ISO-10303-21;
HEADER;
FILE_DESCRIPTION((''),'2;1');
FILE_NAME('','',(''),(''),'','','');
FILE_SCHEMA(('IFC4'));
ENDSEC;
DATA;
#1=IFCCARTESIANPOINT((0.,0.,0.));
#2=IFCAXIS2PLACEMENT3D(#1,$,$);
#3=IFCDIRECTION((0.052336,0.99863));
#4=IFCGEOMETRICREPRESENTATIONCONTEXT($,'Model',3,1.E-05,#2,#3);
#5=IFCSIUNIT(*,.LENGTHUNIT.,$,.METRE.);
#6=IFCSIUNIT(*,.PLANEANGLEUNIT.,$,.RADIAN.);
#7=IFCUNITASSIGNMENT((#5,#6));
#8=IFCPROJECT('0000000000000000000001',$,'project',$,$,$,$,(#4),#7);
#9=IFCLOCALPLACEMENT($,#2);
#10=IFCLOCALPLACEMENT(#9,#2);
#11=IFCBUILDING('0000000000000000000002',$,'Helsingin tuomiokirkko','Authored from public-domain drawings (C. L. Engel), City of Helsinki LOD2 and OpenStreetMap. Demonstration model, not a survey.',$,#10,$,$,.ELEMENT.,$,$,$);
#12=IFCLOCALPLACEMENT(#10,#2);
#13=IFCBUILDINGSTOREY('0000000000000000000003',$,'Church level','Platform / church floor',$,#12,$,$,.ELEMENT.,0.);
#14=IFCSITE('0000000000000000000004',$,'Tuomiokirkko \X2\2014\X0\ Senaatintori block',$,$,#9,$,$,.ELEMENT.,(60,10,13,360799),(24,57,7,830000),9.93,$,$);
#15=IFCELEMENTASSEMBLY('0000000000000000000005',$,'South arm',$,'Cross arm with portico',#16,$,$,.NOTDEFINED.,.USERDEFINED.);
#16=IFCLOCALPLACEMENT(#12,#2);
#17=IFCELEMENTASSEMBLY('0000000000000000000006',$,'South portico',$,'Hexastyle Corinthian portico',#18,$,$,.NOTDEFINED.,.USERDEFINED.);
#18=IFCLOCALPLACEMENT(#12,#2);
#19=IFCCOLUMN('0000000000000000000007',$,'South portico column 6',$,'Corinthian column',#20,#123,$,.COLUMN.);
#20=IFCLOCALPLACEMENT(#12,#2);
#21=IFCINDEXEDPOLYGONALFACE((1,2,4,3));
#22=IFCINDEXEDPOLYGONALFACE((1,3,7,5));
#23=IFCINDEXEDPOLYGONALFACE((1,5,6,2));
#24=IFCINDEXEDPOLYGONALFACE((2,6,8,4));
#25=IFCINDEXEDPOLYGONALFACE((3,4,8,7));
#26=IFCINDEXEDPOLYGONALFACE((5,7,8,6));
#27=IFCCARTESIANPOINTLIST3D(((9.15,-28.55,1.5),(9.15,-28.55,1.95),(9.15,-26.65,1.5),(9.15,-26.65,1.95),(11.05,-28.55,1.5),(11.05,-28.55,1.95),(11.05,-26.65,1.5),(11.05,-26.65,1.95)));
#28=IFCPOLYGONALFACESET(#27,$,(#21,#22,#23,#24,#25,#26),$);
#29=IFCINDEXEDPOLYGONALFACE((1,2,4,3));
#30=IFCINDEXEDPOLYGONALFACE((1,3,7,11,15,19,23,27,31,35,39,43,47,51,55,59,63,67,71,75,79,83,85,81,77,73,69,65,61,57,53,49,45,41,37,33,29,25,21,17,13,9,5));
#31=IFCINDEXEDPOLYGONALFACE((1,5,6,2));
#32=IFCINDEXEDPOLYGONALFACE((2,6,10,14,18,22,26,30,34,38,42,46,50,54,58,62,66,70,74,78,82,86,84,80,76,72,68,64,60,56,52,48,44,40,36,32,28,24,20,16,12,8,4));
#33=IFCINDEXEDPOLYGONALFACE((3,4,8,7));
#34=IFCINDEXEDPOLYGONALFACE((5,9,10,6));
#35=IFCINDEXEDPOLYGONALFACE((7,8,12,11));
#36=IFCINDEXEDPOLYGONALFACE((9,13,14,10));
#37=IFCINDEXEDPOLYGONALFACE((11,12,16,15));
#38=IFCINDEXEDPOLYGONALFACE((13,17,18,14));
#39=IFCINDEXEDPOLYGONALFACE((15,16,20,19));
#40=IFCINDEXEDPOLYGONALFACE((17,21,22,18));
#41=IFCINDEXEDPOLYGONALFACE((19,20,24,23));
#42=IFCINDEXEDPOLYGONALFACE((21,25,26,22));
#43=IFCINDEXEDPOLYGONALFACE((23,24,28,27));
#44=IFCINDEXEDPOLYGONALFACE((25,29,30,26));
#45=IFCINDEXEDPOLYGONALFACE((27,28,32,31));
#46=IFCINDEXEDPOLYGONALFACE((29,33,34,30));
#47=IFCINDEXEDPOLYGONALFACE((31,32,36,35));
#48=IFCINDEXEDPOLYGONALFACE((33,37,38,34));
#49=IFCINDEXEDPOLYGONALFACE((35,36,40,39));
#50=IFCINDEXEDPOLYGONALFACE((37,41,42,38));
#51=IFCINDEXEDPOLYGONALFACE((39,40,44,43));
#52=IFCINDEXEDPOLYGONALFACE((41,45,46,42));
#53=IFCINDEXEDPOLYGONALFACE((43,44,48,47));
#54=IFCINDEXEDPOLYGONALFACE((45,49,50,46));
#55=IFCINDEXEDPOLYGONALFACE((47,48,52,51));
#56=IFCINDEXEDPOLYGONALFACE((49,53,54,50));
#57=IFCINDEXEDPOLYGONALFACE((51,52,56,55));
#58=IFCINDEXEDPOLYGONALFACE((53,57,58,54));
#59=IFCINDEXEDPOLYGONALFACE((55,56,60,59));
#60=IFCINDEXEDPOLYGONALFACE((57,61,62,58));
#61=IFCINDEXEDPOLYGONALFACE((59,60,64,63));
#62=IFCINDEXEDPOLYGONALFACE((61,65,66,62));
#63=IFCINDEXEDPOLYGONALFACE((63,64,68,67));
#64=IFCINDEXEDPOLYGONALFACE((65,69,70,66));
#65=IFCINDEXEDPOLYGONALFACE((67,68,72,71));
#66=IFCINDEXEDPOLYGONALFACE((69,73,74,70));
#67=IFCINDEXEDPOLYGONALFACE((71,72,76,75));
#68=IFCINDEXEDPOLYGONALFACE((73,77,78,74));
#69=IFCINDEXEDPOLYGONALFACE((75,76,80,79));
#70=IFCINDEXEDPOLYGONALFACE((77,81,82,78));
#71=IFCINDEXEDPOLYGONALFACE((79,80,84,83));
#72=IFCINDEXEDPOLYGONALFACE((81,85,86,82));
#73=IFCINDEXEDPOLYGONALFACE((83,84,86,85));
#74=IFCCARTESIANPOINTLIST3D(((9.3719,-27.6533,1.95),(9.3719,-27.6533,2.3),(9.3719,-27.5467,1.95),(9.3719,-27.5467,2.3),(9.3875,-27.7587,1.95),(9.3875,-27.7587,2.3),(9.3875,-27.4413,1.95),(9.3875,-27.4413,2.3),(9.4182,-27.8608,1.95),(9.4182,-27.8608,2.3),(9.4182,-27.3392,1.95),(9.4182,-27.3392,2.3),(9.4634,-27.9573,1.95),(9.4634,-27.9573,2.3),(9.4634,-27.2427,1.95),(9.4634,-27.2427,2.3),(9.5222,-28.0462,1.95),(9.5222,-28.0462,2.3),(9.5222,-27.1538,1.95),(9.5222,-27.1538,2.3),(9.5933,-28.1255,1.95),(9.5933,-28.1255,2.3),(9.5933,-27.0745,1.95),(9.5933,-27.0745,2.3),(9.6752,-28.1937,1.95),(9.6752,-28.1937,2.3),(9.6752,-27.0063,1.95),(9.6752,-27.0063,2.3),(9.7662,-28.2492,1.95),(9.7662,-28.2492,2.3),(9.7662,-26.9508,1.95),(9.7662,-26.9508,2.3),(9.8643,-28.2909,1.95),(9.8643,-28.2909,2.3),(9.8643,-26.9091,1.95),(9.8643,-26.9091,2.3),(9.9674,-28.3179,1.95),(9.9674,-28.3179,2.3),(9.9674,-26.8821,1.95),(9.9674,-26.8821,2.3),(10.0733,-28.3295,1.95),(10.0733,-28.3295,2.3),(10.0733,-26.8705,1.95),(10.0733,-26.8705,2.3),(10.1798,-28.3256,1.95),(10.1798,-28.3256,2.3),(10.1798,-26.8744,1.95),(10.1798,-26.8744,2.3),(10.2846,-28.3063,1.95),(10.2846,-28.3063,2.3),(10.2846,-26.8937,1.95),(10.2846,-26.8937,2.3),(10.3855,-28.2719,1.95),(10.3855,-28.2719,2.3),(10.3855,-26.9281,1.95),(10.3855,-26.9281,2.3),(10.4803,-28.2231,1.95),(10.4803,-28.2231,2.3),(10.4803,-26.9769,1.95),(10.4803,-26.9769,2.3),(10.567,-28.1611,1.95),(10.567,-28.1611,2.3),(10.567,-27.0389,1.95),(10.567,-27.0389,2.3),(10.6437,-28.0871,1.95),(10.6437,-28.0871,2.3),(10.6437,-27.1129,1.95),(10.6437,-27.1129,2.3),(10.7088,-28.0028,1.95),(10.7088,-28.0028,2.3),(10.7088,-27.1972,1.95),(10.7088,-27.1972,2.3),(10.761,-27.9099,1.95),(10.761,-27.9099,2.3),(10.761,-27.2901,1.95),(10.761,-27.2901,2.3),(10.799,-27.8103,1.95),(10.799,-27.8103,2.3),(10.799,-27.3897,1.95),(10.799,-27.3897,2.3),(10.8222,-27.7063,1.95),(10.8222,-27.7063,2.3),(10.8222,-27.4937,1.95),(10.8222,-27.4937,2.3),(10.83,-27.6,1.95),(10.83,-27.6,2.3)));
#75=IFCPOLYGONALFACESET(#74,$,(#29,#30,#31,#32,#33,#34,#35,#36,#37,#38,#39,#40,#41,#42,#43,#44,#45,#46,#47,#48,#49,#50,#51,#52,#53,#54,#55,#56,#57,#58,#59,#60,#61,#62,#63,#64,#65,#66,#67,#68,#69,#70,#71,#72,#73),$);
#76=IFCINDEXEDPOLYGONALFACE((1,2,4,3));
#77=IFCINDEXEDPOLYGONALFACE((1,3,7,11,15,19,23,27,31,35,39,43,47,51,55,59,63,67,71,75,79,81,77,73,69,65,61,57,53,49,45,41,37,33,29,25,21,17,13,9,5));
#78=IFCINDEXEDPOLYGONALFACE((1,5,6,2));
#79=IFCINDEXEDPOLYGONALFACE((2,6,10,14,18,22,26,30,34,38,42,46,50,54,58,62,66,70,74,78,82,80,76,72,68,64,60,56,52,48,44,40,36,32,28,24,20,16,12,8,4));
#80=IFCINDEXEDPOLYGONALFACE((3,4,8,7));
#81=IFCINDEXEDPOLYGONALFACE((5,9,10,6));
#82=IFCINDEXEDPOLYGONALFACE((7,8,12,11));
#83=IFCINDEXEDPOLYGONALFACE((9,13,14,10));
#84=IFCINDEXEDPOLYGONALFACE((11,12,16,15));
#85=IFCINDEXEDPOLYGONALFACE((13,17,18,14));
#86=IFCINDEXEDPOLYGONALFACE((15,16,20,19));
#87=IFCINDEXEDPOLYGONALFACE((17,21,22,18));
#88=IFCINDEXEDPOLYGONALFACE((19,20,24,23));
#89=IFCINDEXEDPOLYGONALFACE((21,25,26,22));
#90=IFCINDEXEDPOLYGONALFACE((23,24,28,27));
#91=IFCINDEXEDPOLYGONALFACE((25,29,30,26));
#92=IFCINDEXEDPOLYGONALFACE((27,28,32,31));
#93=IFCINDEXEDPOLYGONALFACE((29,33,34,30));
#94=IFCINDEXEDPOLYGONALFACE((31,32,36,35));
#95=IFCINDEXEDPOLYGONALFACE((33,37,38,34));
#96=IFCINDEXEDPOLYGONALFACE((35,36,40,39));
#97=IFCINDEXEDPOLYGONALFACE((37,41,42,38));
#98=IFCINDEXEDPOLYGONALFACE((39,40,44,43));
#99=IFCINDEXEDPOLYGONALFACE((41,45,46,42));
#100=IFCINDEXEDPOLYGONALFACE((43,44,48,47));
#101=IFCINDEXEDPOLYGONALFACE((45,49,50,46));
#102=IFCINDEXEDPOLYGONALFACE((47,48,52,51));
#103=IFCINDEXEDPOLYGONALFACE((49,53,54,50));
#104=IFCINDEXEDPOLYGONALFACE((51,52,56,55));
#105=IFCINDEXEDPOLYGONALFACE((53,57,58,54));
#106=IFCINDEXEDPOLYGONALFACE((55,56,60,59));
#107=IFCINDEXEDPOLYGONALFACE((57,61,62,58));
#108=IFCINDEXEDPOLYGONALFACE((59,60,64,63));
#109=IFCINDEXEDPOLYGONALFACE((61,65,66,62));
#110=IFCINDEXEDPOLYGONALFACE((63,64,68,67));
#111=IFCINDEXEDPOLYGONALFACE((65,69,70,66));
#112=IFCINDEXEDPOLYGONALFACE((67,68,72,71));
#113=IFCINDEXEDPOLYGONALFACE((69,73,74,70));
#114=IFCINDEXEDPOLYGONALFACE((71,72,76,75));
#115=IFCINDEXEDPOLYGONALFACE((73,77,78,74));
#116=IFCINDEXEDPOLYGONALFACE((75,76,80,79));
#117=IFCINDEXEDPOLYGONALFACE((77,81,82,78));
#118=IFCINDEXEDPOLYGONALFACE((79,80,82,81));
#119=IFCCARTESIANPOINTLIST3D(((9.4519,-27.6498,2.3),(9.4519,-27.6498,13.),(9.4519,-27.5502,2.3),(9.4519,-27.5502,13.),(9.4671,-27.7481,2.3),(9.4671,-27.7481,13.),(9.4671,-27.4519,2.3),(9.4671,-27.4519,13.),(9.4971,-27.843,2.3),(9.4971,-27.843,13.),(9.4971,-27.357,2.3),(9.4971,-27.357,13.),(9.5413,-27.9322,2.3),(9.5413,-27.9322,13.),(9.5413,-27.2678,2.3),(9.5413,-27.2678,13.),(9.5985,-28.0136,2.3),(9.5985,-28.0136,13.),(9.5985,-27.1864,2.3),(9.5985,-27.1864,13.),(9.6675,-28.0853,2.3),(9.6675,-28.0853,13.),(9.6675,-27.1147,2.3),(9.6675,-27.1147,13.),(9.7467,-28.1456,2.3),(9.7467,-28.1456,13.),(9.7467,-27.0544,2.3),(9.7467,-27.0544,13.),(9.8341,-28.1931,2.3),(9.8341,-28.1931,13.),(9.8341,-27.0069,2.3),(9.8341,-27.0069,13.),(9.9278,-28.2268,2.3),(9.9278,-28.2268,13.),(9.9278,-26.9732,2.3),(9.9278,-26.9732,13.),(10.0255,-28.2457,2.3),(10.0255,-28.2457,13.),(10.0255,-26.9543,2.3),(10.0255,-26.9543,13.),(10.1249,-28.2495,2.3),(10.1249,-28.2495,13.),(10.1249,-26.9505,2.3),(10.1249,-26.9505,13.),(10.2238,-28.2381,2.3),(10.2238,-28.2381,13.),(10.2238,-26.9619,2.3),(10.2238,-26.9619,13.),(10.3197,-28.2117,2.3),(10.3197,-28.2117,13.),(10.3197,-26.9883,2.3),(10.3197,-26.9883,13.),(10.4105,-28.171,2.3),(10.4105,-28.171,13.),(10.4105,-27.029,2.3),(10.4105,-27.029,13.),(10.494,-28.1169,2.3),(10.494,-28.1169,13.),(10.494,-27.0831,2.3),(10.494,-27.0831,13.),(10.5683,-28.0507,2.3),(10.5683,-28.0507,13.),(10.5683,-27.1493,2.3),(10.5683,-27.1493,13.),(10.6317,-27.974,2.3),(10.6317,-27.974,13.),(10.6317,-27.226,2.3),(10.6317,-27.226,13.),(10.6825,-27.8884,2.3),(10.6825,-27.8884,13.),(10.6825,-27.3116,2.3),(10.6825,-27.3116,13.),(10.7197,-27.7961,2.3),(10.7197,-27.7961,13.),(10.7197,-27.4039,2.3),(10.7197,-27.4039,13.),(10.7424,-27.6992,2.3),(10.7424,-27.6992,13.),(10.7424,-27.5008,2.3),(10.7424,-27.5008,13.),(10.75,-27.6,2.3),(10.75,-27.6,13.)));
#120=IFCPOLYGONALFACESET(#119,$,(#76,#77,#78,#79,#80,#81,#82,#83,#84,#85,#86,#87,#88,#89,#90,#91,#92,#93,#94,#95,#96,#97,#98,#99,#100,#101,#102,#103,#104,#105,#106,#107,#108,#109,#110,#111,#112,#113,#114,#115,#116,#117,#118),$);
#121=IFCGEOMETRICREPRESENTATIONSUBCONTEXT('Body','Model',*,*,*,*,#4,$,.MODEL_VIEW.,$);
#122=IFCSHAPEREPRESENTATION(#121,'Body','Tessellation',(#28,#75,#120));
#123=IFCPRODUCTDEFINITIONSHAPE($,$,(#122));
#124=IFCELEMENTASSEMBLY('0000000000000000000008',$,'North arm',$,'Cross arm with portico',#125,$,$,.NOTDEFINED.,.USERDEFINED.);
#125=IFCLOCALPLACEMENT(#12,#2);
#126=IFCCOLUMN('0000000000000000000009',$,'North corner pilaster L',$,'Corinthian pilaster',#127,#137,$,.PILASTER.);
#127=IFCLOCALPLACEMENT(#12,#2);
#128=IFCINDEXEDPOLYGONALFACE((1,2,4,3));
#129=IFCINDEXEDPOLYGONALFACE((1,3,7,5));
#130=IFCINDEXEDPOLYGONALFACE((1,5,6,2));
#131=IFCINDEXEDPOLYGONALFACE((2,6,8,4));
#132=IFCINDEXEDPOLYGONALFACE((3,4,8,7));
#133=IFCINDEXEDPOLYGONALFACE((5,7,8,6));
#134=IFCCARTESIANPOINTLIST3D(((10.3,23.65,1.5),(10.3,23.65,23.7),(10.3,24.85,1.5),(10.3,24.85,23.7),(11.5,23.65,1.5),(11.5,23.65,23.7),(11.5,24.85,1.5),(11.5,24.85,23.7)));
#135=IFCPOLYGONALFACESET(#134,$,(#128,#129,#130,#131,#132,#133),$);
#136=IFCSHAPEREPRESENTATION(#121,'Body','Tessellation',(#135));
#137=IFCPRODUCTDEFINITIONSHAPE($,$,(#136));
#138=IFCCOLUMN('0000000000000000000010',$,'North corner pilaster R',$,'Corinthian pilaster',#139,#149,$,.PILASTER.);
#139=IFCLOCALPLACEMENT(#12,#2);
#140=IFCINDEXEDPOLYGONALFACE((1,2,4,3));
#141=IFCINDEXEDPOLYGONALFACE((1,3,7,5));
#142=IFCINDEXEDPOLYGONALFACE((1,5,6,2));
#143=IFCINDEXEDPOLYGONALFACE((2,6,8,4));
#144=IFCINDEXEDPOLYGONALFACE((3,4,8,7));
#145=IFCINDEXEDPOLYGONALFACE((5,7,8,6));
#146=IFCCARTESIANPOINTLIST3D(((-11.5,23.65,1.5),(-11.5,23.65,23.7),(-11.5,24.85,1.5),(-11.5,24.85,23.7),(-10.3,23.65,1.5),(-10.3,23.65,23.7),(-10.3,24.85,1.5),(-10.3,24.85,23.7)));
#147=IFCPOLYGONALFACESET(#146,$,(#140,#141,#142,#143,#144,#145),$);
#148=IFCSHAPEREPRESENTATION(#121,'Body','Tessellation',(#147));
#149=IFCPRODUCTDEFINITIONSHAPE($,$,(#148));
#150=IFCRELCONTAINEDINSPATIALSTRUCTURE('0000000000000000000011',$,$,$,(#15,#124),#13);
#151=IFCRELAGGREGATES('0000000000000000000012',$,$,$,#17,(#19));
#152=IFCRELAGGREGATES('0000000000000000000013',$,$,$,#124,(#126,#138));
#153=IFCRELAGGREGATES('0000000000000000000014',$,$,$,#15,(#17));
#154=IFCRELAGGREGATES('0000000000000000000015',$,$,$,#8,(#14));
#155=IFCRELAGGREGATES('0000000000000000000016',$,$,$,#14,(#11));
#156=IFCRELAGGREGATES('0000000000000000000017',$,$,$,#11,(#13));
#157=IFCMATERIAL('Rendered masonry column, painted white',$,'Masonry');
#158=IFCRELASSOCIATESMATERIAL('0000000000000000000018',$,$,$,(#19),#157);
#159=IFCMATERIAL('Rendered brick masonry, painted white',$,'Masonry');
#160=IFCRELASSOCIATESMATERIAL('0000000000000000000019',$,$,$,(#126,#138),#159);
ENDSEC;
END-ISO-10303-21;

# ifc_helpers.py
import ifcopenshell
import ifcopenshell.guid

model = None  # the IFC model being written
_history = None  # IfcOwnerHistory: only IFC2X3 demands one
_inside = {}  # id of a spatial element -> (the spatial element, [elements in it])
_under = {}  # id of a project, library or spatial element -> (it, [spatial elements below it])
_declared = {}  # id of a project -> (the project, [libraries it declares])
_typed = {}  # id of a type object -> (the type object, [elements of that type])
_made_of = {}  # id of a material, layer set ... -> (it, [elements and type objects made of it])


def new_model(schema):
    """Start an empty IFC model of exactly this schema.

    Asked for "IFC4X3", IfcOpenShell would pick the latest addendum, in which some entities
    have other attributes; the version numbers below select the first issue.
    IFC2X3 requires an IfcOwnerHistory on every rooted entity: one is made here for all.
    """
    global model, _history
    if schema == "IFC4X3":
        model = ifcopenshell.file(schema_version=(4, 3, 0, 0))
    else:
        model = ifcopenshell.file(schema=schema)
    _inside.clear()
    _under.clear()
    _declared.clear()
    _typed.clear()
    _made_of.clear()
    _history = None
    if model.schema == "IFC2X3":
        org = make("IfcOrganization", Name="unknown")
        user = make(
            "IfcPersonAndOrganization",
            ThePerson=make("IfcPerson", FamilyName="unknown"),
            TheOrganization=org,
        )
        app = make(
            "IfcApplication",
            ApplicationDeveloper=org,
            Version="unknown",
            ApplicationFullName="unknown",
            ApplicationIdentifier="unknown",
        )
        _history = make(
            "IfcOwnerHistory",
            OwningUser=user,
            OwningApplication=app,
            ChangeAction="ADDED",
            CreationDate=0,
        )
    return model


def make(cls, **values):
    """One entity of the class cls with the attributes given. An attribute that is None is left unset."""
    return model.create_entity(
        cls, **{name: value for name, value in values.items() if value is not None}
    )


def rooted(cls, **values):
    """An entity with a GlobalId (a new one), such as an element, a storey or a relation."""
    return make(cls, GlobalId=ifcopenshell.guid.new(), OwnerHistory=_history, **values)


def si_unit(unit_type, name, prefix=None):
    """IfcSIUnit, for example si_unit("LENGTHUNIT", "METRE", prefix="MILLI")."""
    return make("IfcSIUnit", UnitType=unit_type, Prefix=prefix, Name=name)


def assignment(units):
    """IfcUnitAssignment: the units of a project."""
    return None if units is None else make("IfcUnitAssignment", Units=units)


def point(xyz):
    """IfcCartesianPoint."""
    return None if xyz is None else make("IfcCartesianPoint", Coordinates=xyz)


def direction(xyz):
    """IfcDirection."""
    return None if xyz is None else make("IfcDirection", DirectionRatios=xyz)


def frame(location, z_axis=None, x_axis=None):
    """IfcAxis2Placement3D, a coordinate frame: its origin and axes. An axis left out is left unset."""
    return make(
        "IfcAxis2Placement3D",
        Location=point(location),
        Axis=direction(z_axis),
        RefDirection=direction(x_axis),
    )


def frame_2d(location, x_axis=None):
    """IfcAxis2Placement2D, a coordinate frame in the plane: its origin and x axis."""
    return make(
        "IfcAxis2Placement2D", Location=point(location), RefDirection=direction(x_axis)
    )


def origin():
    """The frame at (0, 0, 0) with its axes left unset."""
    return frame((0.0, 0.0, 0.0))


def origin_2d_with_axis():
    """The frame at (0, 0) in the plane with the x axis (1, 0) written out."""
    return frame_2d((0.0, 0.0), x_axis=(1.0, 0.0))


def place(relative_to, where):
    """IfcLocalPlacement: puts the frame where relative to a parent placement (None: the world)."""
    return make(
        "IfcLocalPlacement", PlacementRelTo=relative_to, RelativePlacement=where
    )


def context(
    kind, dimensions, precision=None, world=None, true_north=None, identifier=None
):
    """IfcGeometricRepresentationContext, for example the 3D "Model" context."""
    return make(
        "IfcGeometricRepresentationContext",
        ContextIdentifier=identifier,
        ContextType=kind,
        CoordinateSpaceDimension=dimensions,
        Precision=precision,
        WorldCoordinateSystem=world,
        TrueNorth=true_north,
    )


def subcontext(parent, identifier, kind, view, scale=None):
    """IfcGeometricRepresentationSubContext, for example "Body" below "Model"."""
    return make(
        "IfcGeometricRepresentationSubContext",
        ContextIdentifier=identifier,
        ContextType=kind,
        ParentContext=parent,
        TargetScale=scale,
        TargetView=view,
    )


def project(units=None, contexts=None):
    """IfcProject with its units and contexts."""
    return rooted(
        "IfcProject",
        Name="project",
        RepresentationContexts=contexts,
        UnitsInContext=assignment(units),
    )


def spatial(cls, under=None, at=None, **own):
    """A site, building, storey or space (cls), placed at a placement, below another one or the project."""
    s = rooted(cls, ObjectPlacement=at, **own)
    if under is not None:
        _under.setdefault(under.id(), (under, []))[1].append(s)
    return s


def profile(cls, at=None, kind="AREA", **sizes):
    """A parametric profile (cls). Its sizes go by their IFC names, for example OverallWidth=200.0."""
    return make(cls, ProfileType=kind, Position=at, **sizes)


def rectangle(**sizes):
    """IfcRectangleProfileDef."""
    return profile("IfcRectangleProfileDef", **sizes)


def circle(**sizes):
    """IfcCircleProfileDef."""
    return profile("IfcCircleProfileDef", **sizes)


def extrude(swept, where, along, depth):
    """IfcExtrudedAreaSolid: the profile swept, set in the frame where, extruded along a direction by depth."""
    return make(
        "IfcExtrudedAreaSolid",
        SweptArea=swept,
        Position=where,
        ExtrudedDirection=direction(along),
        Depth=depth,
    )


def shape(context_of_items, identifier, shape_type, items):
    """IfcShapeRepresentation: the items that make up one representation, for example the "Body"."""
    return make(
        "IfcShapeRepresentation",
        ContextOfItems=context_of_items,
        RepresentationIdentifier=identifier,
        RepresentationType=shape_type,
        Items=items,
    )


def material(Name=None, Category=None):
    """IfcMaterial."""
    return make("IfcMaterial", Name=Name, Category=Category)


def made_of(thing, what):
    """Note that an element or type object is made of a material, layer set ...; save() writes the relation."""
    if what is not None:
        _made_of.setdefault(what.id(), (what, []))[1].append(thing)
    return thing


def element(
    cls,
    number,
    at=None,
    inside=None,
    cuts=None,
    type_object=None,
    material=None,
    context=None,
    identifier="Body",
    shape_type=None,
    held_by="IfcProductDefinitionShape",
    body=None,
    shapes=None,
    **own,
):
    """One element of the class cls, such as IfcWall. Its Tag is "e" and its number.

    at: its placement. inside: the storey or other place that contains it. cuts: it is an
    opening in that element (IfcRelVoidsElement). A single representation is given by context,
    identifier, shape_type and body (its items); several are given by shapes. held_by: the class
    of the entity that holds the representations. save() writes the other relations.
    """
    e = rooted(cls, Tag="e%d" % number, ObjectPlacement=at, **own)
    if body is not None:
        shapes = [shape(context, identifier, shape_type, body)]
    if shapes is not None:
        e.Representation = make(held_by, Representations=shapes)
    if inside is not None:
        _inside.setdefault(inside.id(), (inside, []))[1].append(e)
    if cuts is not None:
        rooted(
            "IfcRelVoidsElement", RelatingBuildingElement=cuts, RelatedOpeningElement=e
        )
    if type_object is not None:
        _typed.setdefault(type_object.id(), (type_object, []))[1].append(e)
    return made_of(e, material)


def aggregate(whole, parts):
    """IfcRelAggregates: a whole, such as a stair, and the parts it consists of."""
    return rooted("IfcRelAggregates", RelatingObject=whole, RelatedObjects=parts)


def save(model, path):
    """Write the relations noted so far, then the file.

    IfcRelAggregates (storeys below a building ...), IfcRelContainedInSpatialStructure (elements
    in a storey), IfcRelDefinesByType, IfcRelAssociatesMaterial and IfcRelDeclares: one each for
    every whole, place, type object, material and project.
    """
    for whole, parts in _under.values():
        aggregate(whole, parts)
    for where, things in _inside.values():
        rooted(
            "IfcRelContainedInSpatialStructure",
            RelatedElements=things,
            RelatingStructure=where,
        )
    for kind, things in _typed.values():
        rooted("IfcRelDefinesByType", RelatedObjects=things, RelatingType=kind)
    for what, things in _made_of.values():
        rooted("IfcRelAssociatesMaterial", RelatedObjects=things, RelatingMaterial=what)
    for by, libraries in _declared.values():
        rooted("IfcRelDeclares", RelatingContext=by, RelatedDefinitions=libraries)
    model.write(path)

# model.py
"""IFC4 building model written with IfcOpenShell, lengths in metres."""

from ifc_helpers import new_model, si_unit, direction, frame, origin, origin_2d_with_axis, place, context, subcontext, project, spatial, rectangle, circle, extrude, material, element, aggregate, save


model = new_model("IFC4")

# Units and contexts
model_context = context("Model", 3, precision=1e-05, world=origin(), true_north=direction((0.052336, 0.99863)))
body_context = subcontext(model_context, "Body", "Model", "MODEL_VIEW")
ifc_project = project(units=[si_unit("LENGTHUNIT", "METRE"), si_unit("PLANEANGLEUNIT", "RADIAN")], contexts=[model_context])

# Site, building, storey
site_placement = place(None, origin())
site = spatial("IfcSite", under=ifc_project, at=site_placement, Name="Tuomiokirkko — Senaatintori block", CompositionType="ELEMENT", RefLatitude=(60, 10, 13, 360799), RefLongitude=(24, 57, 7, 830000), RefElevation=9.93)
building_placement = place(site_placement, origin())
building = spatial("IfcBuilding", under=site, at=building_placement, Name="Helsingin tuomiokirkko", Description="Authored from public-domain drawings (C. L. Engel), City of Helsinki LOD2 and OpenStreetMap. Demonstration model, not a survey.", CompositionType="ELEMENT")
storey_placement = place(building_placement, origin())
storey = spatial("IfcBuildingStorey", under=building, at=storey_placement, Name="Church level", Description="Platform / church floor", CompositionType="ELEMENT", Elevation=0.0)

# Element assemblies, columns
assembly_1_placement = place(building_placement, origin())
assembly_1 = element("IfcElementAssembly", 1, at=assembly_1_placement, inside=storey, Name="South arm", ObjectType="Cross arm with portico", AssemblyPlace="NOTDEFINED", PredefinedType="USERDEFINED")
assembly_2_placement = place(building_placement, origin())
assembly_2 = element("IfcElementAssembly", 2, at=assembly_2_placement, Name="South portico", ObjectType="Hexastyle Corinthian portico", AssemblyPlace="NOTDEFINED", PredefinedType="USERDEFINED")
ifc_material_1 = material(Name="Rendered masonry column, painted white", Category="Masonry")
column_1_placement = place(building_placement, origin())
column_1 = element("IfcColumn", 3, at=column_1_placement, material=ifc_material_1, Name="South portico column 6", ObjectType="Corinthian column", PredefinedType="COLUMN", context=body_context, shape_type="SweptSolid", body=[
    extrude(rectangle(XDim=1.9, YDim=1.9, at=origin_2d_with_axis()), frame((10.1, -27.6, 1.5)), (0.0, 0.0, 1.0), 0.45),
    extrude(circle(Radius=0.73, at=origin_2d_with_axis()), frame((10.1, -27.6, 1.95)), (0.0, 0.0, 1.0), 0.35),
    extrude(circle(Radius=0.65, at=origin_2d_with_axis()), frame((10.1, -27.6, 2.3)), (0.0, 0.0, 1.0), 10.7),
])
assembly_3_placement = place(building_placement, origin())
assembly_3 = element("IfcElementAssembly", 4, at=assembly_3_placement, inside=storey, Name="North arm", ObjectType="Cross arm with portico", AssemblyPlace="NOTDEFINED", PredefinedType="USERDEFINED")
ifc_material_2 = material(Name="Rendered brick masonry, painted white", Category="Masonry")
column_2_placement = place(building_placement, origin())
column_2 = element("IfcColumn", 5, at=column_2_placement, material=ifc_material_2, Name="North corner pilaster L", ObjectType="Corinthian pilaster", PredefinedType="PILASTER", context=body_context, shape_type="SweptSolid", body=[
    extrude(rectangle(XDim=1.2, YDim=1.2, at=origin_2d_with_axis()), frame((10.9, 24.25, 1.5)), (0.0, 0.0, 1.0), 22.2),
])
column_3_placement = place(building_placement, origin())
column_3 = element("IfcColumn", 6, at=column_3_placement, material=ifc_material_2, Name="North corner pilaster R", ObjectType="Corinthian pilaster", PredefinedType="PILASTER", context=body_context, shape_type="SweptSolid", body=[
    extrude(rectangle(XDim=1.2, YDim=1.2, at=origin_2d_with_axis()), frame((-10.9, 24.25, 1.5)), (0.0, 0.0, 1.0), 22.2),
])

aggregate(assembly_2, [column_1])
aggregate(assembly_3, [column_2, column_3])

aggregate(assembly_1, [assembly_2])

save(model, "model.ifc")
